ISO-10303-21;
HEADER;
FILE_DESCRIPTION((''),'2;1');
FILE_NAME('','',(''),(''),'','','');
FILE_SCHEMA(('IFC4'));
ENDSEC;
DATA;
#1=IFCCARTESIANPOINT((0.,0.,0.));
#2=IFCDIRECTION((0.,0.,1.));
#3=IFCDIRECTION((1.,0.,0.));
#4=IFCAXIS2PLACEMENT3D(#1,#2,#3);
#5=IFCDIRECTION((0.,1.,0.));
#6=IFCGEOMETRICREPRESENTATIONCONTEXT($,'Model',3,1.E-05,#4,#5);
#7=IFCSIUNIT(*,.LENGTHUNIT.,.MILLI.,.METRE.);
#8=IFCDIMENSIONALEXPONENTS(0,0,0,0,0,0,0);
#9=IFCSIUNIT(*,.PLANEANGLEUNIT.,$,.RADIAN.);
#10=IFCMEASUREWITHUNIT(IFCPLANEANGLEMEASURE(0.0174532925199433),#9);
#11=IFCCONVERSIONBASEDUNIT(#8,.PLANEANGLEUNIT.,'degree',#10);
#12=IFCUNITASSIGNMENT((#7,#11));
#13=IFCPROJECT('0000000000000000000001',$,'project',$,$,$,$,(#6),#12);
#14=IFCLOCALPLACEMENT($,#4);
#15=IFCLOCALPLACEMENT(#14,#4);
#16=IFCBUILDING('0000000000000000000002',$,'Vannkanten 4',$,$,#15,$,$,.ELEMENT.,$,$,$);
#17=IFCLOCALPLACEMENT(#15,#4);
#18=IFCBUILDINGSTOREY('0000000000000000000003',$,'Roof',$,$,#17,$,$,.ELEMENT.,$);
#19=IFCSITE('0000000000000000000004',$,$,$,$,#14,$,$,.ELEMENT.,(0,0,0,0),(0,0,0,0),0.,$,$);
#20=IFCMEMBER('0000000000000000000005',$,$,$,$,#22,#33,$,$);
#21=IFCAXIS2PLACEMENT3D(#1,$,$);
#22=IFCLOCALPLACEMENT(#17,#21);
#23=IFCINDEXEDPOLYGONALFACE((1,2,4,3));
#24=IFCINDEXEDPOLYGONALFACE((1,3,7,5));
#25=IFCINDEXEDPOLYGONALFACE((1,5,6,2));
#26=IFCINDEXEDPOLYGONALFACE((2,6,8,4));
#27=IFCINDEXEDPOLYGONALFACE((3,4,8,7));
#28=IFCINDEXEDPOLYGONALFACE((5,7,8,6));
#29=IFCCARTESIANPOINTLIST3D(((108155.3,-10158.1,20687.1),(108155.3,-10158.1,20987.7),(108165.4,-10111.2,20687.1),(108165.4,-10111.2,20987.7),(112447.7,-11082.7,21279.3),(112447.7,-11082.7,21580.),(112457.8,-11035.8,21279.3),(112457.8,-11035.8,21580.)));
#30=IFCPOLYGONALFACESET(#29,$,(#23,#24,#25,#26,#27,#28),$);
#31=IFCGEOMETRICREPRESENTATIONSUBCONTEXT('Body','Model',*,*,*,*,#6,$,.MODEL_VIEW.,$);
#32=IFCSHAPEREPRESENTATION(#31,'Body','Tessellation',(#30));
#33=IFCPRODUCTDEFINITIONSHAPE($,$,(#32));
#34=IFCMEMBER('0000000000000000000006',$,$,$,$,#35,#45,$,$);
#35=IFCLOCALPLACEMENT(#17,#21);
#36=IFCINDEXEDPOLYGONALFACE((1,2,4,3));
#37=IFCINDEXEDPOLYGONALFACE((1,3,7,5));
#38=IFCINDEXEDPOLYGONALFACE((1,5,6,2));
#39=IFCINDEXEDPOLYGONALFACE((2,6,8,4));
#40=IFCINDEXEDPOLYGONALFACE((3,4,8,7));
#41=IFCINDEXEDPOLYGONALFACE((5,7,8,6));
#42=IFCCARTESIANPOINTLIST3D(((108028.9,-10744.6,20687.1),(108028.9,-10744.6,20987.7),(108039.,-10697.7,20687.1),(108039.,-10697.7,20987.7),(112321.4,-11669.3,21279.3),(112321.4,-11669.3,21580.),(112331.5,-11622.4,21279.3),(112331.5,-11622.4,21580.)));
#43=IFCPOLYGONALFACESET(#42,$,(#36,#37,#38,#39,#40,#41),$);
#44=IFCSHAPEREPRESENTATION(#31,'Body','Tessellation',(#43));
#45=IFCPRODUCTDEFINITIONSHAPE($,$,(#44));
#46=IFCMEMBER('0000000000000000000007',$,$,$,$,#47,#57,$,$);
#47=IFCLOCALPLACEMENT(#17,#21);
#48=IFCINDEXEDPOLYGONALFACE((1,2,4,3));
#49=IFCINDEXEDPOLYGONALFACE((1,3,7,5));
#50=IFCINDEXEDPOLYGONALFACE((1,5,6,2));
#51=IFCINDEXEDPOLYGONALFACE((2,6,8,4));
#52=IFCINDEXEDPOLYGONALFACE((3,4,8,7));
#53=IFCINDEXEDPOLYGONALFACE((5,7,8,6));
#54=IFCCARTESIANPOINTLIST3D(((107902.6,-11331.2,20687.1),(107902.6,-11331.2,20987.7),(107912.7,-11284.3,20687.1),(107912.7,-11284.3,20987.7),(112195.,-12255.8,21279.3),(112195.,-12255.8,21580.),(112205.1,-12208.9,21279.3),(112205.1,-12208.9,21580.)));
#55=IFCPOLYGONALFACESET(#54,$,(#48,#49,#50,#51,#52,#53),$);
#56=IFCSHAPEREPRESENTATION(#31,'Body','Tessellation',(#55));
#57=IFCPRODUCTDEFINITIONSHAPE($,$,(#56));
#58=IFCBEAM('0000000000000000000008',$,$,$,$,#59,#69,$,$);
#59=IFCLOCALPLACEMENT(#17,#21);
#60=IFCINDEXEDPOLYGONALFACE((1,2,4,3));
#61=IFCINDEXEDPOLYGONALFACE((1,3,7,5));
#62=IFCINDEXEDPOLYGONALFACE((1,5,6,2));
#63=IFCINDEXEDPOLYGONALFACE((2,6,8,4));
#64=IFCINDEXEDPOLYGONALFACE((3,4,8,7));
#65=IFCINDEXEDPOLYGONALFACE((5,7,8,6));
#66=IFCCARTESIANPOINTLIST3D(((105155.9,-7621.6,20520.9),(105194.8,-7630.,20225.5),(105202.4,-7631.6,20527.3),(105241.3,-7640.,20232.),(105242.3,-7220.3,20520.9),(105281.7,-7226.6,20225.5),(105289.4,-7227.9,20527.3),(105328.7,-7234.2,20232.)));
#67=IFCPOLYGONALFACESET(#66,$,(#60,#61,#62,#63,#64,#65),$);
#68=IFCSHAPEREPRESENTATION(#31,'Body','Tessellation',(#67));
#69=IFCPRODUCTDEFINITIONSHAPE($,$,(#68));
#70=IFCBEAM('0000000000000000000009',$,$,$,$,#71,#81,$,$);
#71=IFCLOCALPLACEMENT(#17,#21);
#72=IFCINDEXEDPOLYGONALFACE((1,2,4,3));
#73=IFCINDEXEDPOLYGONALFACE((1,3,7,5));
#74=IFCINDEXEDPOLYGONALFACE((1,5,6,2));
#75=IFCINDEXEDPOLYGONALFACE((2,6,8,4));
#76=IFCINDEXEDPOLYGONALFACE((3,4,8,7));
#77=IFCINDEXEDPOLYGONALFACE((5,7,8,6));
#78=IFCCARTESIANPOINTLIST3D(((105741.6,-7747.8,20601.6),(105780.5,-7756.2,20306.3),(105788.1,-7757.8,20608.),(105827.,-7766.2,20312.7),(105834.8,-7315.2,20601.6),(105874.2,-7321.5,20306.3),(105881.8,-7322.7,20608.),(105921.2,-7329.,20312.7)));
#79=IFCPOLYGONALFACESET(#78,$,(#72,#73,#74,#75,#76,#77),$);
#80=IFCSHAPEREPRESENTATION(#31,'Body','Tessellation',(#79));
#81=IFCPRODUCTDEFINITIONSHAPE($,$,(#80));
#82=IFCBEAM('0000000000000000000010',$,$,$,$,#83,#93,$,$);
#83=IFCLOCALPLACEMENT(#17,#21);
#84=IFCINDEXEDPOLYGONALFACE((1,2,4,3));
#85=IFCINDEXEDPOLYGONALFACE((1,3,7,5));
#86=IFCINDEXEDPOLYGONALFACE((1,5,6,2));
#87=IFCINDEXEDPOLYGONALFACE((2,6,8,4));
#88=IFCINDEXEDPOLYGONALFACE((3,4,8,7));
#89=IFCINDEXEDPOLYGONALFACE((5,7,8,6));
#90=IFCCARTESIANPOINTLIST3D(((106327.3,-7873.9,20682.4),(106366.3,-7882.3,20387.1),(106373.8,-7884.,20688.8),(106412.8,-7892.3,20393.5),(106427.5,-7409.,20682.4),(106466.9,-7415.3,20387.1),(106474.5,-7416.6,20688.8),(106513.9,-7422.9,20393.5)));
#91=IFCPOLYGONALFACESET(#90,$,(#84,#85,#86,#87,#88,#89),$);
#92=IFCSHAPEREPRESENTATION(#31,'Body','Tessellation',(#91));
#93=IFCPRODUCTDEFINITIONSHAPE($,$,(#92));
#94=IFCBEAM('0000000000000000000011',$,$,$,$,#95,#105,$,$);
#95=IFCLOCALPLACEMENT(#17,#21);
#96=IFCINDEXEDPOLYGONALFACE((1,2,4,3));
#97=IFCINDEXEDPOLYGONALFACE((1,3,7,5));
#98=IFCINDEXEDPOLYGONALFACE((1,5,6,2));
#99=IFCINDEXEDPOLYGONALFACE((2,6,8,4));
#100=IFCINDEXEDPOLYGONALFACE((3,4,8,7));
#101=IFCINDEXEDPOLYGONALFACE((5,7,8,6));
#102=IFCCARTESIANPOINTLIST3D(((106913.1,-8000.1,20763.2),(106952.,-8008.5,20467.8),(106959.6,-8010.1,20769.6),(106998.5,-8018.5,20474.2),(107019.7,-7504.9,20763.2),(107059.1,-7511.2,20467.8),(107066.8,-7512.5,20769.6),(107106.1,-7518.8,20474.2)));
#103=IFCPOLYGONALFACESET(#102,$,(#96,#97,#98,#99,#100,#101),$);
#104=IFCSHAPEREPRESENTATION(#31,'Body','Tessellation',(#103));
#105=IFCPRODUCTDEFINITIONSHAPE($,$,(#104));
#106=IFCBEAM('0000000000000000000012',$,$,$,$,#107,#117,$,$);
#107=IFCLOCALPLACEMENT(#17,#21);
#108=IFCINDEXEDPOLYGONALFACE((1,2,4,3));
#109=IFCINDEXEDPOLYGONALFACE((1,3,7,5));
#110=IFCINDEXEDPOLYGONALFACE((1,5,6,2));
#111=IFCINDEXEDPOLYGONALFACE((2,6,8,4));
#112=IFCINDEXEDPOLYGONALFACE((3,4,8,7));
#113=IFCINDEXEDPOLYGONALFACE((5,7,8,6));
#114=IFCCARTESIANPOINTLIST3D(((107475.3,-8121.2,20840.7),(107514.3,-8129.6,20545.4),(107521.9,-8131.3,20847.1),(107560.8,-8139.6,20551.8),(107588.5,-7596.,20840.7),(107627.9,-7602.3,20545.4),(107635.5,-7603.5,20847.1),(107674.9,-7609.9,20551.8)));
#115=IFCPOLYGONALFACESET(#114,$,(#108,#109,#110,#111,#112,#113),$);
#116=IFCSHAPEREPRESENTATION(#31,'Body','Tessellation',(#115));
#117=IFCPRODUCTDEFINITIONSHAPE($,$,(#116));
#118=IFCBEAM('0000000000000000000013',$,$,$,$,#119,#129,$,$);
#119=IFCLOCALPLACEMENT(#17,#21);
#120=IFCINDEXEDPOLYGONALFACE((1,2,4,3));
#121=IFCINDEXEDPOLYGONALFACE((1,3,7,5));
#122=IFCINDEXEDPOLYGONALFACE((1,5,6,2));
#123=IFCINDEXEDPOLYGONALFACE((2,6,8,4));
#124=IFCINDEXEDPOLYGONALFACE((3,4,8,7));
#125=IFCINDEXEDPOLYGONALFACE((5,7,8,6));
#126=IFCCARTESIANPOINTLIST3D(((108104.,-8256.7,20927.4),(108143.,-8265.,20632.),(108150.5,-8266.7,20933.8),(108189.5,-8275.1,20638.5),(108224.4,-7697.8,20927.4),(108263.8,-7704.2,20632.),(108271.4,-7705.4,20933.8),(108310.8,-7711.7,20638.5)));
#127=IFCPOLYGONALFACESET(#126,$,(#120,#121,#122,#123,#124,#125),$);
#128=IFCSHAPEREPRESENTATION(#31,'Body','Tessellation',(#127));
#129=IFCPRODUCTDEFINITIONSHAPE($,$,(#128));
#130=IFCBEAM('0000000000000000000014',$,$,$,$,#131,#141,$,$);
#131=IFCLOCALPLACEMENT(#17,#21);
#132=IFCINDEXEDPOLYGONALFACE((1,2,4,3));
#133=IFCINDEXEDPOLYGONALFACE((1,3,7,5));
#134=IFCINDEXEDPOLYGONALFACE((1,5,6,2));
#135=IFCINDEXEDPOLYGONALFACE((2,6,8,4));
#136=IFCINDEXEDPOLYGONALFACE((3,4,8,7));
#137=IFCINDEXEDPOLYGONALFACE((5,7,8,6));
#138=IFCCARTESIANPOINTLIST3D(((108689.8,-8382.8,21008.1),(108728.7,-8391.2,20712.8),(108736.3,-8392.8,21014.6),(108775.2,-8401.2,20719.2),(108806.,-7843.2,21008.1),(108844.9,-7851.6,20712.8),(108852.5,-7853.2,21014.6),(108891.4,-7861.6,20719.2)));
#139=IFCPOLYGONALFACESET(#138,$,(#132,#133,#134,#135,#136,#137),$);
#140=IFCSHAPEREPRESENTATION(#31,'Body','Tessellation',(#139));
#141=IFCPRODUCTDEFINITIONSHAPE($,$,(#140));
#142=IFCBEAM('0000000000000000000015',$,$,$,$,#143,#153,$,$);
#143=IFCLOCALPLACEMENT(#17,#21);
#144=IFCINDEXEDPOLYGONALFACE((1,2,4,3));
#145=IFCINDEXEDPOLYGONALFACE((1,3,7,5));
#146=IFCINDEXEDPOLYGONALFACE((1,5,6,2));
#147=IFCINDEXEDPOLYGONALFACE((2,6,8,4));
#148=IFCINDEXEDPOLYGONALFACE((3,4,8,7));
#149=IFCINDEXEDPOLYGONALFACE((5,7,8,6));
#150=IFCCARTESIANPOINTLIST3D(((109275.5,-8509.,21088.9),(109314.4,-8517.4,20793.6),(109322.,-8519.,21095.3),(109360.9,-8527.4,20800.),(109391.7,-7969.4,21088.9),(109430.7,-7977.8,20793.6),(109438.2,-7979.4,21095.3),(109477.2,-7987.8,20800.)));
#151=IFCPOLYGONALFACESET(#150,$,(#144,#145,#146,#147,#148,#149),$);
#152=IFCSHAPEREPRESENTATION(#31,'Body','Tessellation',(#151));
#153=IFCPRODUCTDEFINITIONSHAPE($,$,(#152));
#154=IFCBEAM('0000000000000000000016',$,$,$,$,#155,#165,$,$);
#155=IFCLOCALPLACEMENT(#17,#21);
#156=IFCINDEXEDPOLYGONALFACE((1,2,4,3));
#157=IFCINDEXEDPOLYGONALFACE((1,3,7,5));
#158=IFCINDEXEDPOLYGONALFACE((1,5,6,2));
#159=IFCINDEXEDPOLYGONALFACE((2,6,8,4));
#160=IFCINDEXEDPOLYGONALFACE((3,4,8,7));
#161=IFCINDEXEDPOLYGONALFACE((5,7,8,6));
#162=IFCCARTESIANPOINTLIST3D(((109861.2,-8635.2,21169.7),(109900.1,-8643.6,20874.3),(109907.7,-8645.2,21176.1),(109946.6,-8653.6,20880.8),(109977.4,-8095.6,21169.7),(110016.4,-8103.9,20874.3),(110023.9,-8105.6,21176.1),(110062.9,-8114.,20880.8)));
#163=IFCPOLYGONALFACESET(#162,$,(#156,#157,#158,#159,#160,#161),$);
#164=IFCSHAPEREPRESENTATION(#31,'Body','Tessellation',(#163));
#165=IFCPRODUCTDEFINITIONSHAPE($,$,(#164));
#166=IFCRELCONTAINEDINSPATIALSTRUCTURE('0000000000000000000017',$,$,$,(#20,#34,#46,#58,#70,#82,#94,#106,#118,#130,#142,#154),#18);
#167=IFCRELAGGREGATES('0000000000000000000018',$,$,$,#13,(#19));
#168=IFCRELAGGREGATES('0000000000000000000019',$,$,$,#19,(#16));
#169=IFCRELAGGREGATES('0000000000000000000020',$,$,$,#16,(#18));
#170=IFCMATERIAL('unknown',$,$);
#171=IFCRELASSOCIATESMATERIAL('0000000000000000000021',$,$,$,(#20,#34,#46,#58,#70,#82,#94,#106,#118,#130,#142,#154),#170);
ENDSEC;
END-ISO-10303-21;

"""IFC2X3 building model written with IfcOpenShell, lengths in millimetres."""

from ifc_helpers import new_model, entity, si_unit, converted_unit, direction, frame, origin_with_axes, place, context, subcontext, project, spatial, polyline, segment, composite_curve, outline, extrude, clip, halfspace, material, element, save


model = new_model("IFC2X3")

# Units and contexts
model_context = context("Model", 3, precision=1e-05, world=origin_with_axes(), true_north=direction((0.0, 1.0, 0.0)))
body_context = subcontext(model_context, "Body", "Model", "MODEL_VIEW")
ifc_project = project(units=[si_unit("LENGTHUNIT", "METRE", prefix="MILLI"), converted_unit("PLANEANGLEUNIT", "degree", entity("IfcPlaneAngleMeasure", 0.0174532925199433), si_unit("PLANEANGLEUNIT", "RADIAN"), dimensions=[0, 0, 0, 0, 0, 0, 0])], contexts=[model_context])

# Site, building, storey
site_placement = place(None, origin_with_axes())
site = spatial("IfcSite", under=ifc_project, at=site_placement, CompositionType="ELEMENT", RefLatitude=(0, 0, 0, 0), RefLongitude=(0, 0, 0, 0), RefElevation=0.0)
building_placement = place(site_placement, origin_with_axes())
building = spatial("IfcBuilding", under=site, at=building_placement, Name="Vannkanten 4", CompositionType="ELEMENT")
storey_placement = place(building_placement, origin_with_axes())
storey = spatial("IfcBuildingStorey", under=building, at=storey_placement, Name="Roof", CompositionType="ELEMENT")

# Members
ifc_material = material(Name="unknown")
member_1_placement = place(storey_placement, frame((108160.3, -10134.6, 20837.4), z_axis=(0.968803, -0.208692, 0.133675), x_axis=(0.210582, 0.977576, 0.0)))
element("IfcMember", 1, at=member_1_placement, inside=storey, material=ifc_material, context=body_context, shape_type="Clipping", body=[
    clip(clip(extrude(outline(composite_curve([segment(polyline([(-24.0, -149.0), (-24.0, 149.0), (24.0, 149.0), (24.0, -149.0), (-24.0, -149.0)]), True, "CONTINUOUS")], self_intersect=False)), frame((0.0, 0.0, -2255.5), z_axis=(0.0, 0.0, 1.0), x_axis=(1.0, 0.0, 0.0)), (0.0, 0.0, 1.0), 8941.7), halfspace(frame((-24.0, 149.0, 20.1), z_axis=(0.0, -0.133675, 0.991025), x_axis=(0.0, 0.991025, 0.133675)), True)), halfspace(frame((24.0, 149.0, 4450.8), z_axis=(0.0, 0.133675, -0.991025), x_axis=(0.0, -0.991025, -0.133675)), True)),
])
member_2_placement = place(storey_placement, frame((108034.0, -10721.2, 20837.4), z_axis=(0.968803, -0.208692, 0.133675), x_axis=(0.210582, 0.977576, 0.0)))
element("IfcMember", 2, at=member_2_placement, inside=storey, material=ifc_material, context=body_context, shape_type="Clipping", body=[
    clip(clip(extrude(outline(composite_curve([segment(polyline([(-24.0, -149.0), (-24.0, 149.0), (24.0, 149.0), (24.0, -149.0), (-24.0, -149.0)]), True, "CONTINUOUS")], self_intersect=False)), frame((0.0, 0.0, -2255.5), z_axis=(0.0, 0.0, 1.0), x_axis=(1.0, 0.0, 0.0)), (0.0, 0.0, 1.0), 8941.7), halfspace(frame((-24.0, 149.0, 20.1), z_axis=(0.0, -0.133675, 0.991025), x_axis=(0.0, 0.991025, 0.133675)), True)), halfspace(frame((24.0, 149.0, 4450.8), z_axis=(0.0, 0.133675, -0.991025), x_axis=(0.0, -0.991025, -0.133675)), True)),
])
member_3_placement = place(storey_placement, frame((107907.6, -11307.7, 20837.4), z_axis=(0.968803, -0.208692, 0.133675), x_axis=(0.210582, 0.977576, 0.0)))
element("IfcMember", 3, at=member_3_placement, inside=storey, material=ifc_material, context=body_context, shape_type="Clipping", body=[
    clip(clip(extrude(outline(composite_curve([segment(polyline([(-24.0, -149.0), (-24.0, 149.0), (24.0, 149.0), (24.0, -149.0), (-24.0, -149.0)]), True, "CONTINUOUS")], self_intersect=False)), frame((0.0, 0.0, -2255.5), z_axis=(0.0, 0.0, 1.0), x_axis=(1.0, 0.0, 0.0)), (0.0, 0.0, 1.0), 8941.7), halfspace(frame((-24.0, 149.0, 20.1), z_axis=(0.0, -0.133675, 0.991025), x_axis=(0.0, 0.991025, 0.133675)), True)), halfspace(frame((24.0, 149.0, 4450.8), z_axis=(0.0, 0.133675, -0.991025), x_axis=(0.0, -0.991025, -0.133675)), True)),
])

# Beams
beam_1_placement = place(storey_placement, frame((105198.6, -7630.8, 20376.4), z_axis=(0.210582, 0.977576, 0.0), x_axis=(-0.968803, 0.208692, -0.133675)))
element("IfcBeam", 4, at=beam_1_placement, inside=storey, material=ifc_material, context=body_context, shape_type="Clipping", body=[
    clip(extrude(outline(composite_curve([segment(polyline([(-24.0, -149.0), (-24.0, 149.0), (24.0, 149.0), (24.0, -149.0), (-24.0, -149.0)]), True, "CONTINUOUS")], self_intersect=False)), frame((0.0, 0.0, 0.0), z_axis=(0.0, 0.0, 1.0), x_axis=(1.0, 0.0, 0.0)), (0.0, 0.0, 1.0), 622.7), halfspace(frame((-24.0, -149.0, 415.2), z_axis=(-0.052883, -0.007133, -0.998575), x_axis=(-0.998601, 0.0, 0.052884)), True)),
])
beam_2_placement = place(storey_placement, frame((105784.3, -7757.0, 20457.2), z_axis=(0.210582, 0.977576, 0.0), x_axis=(-0.968803, 0.208692, -0.133675)))
element("IfcBeam", 5, at=beam_2_placement, inside=storey, material=ifc_material, context=body_context, shape_type="Clipping", body=[
    clip(extrude(outline(composite_curve([segment(polyline([(-24.0, -149.0), (-24.0, 149.0), (24.0, 149.0), (24.0, -149.0), (-24.0, -149.0)]), True, "CONTINUOUS")], self_intersect=False)), frame((0.0, 0.0, 0.0), z_axis=(0.0, 0.0, 1.0), x_axis=(1.0, 0.0, 0.0)), (0.0, 0.0, 1.0), 670.8), halfspace(frame((-24.0, -149.0, 447.2), z_axis=(-0.052883, -0.007133, -0.998575), x_axis=(-0.998601, 0.0, 0.052884)), True)),
])
beam_3_placement = place(storey_placement, frame((106370.1, -7883.1, 20537.9), z_axis=(0.210582, 0.977576, 0.0), x_axis=(-0.968803, 0.208692, -0.133675)))
element("IfcBeam", 6, at=beam_3_placement, inside=storey, material=ifc_material, context=body_context, shape_type="Clipping", body=[
    clip(extrude(outline(composite_curve([segment(polyline([(-24.0, -149.0), (-24.0, 149.0), (24.0, 149.0), (24.0, -149.0), (-24.0, -149.0)]), True, "CONTINUOUS")], self_intersect=False)), frame((0.0, 0.0, 0.0), z_axis=(0.0, 0.0, 1.0), x_axis=(1.0, 0.0, 0.0)), (0.0, 0.0, 1.0), 720.3), halfspace(frame((-24.0, -149.0, 480.2), z_axis=(-0.052883, -0.007133, -0.998575), x_axis=(-0.998601, 0.0, 0.052884)), True)),
])
beam_4_placement = place(storey_placement, frame((106955.8, -8009.3, 20618.7), z_axis=(0.210582, 0.977576, 0.0), x_axis=(-0.968803, 0.208692, -0.133675)))
element("IfcBeam", 7, at=beam_4_placement, inside=storey, material=ifc_material, context=body_context, shape_type="Clipping", body=[
    clip(extrude(outline(composite_curve([segment(polyline([(-24.0, -149.0), (-24.0, 149.0), (24.0, 149.0), (24.0, -149.0), (-24.0, -149.0)]), True, "CONTINUOUS")], self_intersect=False)), frame((0.0, 0.0, 0.0), z_axis=(0.0, 0.0, 1.0), x_axis=(1.0, 0.0, 0.0)), (0.0, 0.0, 1.0), 766.8), halfspace(frame((-24.0, -149.0, 511.2), z_axis=(-0.052883, -0.007133, -0.998575), x_axis=(-0.998601, 0.0, 0.052884)), True)),
])
beam_5_placement = place(storey_placement, frame((107518.1, -8130.4, 20696.2), z_axis=(0.210582, 0.977576, 0.0), x_axis=(-0.968803, 0.208692, -0.133675)))
element("IfcBeam", 8, at=beam_5_placement, inside=storey, material=ifc_material, context=body_context, shape_type="Clipping", body=[
    clip(extrude(outline(composite_curve([segment(polyline([(-24.0, -149.0), (-24.0, 149.0), (24.0, 149.0), (24.0, -149.0), (-24.0, -149.0)]), True, "CONTINUOUS")], self_intersect=False)), frame((0.0, 0.0, 0.0), z_axis=(0.0, 0.0, 1.0), x_axis=(1.0, 0.0, 0.0)), (0.0, 0.0, 1.0), 812.9), halfspace(frame((-24.0, -149.0, 541.9), z_axis=(-0.052883, -0.007133, -0.998575), x_axis=(-0.998601, 0.0, 0.052884)), True)),
])
beam_6_placement = place(storey_placement, frame((108146.7, -8265.9, 20782.9), z_axis=(0.210582, 0.977576, 0.0), x_axis=(-0.968803, 0.208692, -0.133675)))
element("IfcBeam", 9, at=beam_6_placement, inside=storey, material=ifc_material, context=body_context, shape_type="Clipping", body=[
    clip(extrude(outline(composite_curve([segment(polyline([(-24.0, -149.0), (-24.0, 149.0), (24.0, 149.0), (24.0, -149.0), (-24.0, -149.0)]), True, "CONTINUOUS")], self_intersect=False)), frame((0.0, 0.0, 0.0), z_axis=(0.0, 0.0, 1.0), x_axis=(1.0, 0.0, 0.0)), (0.0, 0.0, 1.0), 864.5), halfspace(frame((-24.0, -149.0, 576.3), z_axis=(-0.052883, -0.007133, -0.998575), x_axis=(-0.998601, 0.0, 0.052884)), True)),
])
beam_7_placement = place(storey_placement, frame((108732.5, -8392.0, 20863.7), z_axis=(0.210582, 0.977576, 0.0), x_axis=(-0.968803, 0.208692, -0.133675)))
element("IfcBeam", 10, at=beam_7_placement, inside=storey, material=ifc_material, context=body_context, shape_type="SweptSolid", body=[
    extrude(outline(composite_curve([segment(polyline([(-24.0, -149.0), (-24.0, 149.0), (24.0, 149.0), (24.0, -149.0), (-24.0, -149.0)]), True, "CONTINUOUS")], self_intersect=False)), frame((0.0, 0.0, 0.0), z_axis=(0.0, 0.0, 1.0), x_axis=(1.0, 0.0, 0.0)), (0.0, 0.0, 1.0), 552.0),
])
beam_8_placement = place(storey_placement, frame((109318.2, -8518.2, 20944.4), z_axis=(0.210582, 0.977576, 0.0), x_axis=(-0.968803, 0.208692, -0.133675)))
element("IfcBeam", 11, at=beam_8_placement, inside=storey, material=ifc_material, context=body_context, shape_type="SweptSolid", body=[
    extrude(outline(composite_curve([segment(polyline([(-24.0, -149.0), (-24.0, 149.0), (24.0, 149.0), (24.0, -149.0), (-24.0, -149.0)]), True, "CONTINUOUS")], self_intersect=False)), frame((0.0, 0.0, 0.0), z_axis=(0.0, 0.0, 1.0), x_axis=(1.0, 0.0, 0.0)), (0.0, 0.0, 1.0), 552.0),
])
beam_9_placement = place(storey_placement, frame((109903.9, -8644.4, 21025.2), z_axis=(0.210582, 0.977576, 0.0), x_axis=(-0.968803, 0.208692, -0.133675)))
element("IfcBeam", 12, at=beam_9_placement, inside=storey, material=ifc_material, context=body_context, shape_type="SweptSolid", body=[
    extrude(outline(composite_curve([segment(polyline([(-24.0, -149.0), (-24.0, 149.0), (24.0, 149.0), (24.0, -149.0), (-24.0, -149.0)]), True, "CONTINUOUS")], self_intersect=False)), frame((0.0, 0.0, 0.0), z_axis=(0.0, 0.0, 1.0), x_axis=(1.0, 0.0, 0.0)), (0.0, 0.0, 1.0), 552.0),
])

save(model, "model.ifc")
